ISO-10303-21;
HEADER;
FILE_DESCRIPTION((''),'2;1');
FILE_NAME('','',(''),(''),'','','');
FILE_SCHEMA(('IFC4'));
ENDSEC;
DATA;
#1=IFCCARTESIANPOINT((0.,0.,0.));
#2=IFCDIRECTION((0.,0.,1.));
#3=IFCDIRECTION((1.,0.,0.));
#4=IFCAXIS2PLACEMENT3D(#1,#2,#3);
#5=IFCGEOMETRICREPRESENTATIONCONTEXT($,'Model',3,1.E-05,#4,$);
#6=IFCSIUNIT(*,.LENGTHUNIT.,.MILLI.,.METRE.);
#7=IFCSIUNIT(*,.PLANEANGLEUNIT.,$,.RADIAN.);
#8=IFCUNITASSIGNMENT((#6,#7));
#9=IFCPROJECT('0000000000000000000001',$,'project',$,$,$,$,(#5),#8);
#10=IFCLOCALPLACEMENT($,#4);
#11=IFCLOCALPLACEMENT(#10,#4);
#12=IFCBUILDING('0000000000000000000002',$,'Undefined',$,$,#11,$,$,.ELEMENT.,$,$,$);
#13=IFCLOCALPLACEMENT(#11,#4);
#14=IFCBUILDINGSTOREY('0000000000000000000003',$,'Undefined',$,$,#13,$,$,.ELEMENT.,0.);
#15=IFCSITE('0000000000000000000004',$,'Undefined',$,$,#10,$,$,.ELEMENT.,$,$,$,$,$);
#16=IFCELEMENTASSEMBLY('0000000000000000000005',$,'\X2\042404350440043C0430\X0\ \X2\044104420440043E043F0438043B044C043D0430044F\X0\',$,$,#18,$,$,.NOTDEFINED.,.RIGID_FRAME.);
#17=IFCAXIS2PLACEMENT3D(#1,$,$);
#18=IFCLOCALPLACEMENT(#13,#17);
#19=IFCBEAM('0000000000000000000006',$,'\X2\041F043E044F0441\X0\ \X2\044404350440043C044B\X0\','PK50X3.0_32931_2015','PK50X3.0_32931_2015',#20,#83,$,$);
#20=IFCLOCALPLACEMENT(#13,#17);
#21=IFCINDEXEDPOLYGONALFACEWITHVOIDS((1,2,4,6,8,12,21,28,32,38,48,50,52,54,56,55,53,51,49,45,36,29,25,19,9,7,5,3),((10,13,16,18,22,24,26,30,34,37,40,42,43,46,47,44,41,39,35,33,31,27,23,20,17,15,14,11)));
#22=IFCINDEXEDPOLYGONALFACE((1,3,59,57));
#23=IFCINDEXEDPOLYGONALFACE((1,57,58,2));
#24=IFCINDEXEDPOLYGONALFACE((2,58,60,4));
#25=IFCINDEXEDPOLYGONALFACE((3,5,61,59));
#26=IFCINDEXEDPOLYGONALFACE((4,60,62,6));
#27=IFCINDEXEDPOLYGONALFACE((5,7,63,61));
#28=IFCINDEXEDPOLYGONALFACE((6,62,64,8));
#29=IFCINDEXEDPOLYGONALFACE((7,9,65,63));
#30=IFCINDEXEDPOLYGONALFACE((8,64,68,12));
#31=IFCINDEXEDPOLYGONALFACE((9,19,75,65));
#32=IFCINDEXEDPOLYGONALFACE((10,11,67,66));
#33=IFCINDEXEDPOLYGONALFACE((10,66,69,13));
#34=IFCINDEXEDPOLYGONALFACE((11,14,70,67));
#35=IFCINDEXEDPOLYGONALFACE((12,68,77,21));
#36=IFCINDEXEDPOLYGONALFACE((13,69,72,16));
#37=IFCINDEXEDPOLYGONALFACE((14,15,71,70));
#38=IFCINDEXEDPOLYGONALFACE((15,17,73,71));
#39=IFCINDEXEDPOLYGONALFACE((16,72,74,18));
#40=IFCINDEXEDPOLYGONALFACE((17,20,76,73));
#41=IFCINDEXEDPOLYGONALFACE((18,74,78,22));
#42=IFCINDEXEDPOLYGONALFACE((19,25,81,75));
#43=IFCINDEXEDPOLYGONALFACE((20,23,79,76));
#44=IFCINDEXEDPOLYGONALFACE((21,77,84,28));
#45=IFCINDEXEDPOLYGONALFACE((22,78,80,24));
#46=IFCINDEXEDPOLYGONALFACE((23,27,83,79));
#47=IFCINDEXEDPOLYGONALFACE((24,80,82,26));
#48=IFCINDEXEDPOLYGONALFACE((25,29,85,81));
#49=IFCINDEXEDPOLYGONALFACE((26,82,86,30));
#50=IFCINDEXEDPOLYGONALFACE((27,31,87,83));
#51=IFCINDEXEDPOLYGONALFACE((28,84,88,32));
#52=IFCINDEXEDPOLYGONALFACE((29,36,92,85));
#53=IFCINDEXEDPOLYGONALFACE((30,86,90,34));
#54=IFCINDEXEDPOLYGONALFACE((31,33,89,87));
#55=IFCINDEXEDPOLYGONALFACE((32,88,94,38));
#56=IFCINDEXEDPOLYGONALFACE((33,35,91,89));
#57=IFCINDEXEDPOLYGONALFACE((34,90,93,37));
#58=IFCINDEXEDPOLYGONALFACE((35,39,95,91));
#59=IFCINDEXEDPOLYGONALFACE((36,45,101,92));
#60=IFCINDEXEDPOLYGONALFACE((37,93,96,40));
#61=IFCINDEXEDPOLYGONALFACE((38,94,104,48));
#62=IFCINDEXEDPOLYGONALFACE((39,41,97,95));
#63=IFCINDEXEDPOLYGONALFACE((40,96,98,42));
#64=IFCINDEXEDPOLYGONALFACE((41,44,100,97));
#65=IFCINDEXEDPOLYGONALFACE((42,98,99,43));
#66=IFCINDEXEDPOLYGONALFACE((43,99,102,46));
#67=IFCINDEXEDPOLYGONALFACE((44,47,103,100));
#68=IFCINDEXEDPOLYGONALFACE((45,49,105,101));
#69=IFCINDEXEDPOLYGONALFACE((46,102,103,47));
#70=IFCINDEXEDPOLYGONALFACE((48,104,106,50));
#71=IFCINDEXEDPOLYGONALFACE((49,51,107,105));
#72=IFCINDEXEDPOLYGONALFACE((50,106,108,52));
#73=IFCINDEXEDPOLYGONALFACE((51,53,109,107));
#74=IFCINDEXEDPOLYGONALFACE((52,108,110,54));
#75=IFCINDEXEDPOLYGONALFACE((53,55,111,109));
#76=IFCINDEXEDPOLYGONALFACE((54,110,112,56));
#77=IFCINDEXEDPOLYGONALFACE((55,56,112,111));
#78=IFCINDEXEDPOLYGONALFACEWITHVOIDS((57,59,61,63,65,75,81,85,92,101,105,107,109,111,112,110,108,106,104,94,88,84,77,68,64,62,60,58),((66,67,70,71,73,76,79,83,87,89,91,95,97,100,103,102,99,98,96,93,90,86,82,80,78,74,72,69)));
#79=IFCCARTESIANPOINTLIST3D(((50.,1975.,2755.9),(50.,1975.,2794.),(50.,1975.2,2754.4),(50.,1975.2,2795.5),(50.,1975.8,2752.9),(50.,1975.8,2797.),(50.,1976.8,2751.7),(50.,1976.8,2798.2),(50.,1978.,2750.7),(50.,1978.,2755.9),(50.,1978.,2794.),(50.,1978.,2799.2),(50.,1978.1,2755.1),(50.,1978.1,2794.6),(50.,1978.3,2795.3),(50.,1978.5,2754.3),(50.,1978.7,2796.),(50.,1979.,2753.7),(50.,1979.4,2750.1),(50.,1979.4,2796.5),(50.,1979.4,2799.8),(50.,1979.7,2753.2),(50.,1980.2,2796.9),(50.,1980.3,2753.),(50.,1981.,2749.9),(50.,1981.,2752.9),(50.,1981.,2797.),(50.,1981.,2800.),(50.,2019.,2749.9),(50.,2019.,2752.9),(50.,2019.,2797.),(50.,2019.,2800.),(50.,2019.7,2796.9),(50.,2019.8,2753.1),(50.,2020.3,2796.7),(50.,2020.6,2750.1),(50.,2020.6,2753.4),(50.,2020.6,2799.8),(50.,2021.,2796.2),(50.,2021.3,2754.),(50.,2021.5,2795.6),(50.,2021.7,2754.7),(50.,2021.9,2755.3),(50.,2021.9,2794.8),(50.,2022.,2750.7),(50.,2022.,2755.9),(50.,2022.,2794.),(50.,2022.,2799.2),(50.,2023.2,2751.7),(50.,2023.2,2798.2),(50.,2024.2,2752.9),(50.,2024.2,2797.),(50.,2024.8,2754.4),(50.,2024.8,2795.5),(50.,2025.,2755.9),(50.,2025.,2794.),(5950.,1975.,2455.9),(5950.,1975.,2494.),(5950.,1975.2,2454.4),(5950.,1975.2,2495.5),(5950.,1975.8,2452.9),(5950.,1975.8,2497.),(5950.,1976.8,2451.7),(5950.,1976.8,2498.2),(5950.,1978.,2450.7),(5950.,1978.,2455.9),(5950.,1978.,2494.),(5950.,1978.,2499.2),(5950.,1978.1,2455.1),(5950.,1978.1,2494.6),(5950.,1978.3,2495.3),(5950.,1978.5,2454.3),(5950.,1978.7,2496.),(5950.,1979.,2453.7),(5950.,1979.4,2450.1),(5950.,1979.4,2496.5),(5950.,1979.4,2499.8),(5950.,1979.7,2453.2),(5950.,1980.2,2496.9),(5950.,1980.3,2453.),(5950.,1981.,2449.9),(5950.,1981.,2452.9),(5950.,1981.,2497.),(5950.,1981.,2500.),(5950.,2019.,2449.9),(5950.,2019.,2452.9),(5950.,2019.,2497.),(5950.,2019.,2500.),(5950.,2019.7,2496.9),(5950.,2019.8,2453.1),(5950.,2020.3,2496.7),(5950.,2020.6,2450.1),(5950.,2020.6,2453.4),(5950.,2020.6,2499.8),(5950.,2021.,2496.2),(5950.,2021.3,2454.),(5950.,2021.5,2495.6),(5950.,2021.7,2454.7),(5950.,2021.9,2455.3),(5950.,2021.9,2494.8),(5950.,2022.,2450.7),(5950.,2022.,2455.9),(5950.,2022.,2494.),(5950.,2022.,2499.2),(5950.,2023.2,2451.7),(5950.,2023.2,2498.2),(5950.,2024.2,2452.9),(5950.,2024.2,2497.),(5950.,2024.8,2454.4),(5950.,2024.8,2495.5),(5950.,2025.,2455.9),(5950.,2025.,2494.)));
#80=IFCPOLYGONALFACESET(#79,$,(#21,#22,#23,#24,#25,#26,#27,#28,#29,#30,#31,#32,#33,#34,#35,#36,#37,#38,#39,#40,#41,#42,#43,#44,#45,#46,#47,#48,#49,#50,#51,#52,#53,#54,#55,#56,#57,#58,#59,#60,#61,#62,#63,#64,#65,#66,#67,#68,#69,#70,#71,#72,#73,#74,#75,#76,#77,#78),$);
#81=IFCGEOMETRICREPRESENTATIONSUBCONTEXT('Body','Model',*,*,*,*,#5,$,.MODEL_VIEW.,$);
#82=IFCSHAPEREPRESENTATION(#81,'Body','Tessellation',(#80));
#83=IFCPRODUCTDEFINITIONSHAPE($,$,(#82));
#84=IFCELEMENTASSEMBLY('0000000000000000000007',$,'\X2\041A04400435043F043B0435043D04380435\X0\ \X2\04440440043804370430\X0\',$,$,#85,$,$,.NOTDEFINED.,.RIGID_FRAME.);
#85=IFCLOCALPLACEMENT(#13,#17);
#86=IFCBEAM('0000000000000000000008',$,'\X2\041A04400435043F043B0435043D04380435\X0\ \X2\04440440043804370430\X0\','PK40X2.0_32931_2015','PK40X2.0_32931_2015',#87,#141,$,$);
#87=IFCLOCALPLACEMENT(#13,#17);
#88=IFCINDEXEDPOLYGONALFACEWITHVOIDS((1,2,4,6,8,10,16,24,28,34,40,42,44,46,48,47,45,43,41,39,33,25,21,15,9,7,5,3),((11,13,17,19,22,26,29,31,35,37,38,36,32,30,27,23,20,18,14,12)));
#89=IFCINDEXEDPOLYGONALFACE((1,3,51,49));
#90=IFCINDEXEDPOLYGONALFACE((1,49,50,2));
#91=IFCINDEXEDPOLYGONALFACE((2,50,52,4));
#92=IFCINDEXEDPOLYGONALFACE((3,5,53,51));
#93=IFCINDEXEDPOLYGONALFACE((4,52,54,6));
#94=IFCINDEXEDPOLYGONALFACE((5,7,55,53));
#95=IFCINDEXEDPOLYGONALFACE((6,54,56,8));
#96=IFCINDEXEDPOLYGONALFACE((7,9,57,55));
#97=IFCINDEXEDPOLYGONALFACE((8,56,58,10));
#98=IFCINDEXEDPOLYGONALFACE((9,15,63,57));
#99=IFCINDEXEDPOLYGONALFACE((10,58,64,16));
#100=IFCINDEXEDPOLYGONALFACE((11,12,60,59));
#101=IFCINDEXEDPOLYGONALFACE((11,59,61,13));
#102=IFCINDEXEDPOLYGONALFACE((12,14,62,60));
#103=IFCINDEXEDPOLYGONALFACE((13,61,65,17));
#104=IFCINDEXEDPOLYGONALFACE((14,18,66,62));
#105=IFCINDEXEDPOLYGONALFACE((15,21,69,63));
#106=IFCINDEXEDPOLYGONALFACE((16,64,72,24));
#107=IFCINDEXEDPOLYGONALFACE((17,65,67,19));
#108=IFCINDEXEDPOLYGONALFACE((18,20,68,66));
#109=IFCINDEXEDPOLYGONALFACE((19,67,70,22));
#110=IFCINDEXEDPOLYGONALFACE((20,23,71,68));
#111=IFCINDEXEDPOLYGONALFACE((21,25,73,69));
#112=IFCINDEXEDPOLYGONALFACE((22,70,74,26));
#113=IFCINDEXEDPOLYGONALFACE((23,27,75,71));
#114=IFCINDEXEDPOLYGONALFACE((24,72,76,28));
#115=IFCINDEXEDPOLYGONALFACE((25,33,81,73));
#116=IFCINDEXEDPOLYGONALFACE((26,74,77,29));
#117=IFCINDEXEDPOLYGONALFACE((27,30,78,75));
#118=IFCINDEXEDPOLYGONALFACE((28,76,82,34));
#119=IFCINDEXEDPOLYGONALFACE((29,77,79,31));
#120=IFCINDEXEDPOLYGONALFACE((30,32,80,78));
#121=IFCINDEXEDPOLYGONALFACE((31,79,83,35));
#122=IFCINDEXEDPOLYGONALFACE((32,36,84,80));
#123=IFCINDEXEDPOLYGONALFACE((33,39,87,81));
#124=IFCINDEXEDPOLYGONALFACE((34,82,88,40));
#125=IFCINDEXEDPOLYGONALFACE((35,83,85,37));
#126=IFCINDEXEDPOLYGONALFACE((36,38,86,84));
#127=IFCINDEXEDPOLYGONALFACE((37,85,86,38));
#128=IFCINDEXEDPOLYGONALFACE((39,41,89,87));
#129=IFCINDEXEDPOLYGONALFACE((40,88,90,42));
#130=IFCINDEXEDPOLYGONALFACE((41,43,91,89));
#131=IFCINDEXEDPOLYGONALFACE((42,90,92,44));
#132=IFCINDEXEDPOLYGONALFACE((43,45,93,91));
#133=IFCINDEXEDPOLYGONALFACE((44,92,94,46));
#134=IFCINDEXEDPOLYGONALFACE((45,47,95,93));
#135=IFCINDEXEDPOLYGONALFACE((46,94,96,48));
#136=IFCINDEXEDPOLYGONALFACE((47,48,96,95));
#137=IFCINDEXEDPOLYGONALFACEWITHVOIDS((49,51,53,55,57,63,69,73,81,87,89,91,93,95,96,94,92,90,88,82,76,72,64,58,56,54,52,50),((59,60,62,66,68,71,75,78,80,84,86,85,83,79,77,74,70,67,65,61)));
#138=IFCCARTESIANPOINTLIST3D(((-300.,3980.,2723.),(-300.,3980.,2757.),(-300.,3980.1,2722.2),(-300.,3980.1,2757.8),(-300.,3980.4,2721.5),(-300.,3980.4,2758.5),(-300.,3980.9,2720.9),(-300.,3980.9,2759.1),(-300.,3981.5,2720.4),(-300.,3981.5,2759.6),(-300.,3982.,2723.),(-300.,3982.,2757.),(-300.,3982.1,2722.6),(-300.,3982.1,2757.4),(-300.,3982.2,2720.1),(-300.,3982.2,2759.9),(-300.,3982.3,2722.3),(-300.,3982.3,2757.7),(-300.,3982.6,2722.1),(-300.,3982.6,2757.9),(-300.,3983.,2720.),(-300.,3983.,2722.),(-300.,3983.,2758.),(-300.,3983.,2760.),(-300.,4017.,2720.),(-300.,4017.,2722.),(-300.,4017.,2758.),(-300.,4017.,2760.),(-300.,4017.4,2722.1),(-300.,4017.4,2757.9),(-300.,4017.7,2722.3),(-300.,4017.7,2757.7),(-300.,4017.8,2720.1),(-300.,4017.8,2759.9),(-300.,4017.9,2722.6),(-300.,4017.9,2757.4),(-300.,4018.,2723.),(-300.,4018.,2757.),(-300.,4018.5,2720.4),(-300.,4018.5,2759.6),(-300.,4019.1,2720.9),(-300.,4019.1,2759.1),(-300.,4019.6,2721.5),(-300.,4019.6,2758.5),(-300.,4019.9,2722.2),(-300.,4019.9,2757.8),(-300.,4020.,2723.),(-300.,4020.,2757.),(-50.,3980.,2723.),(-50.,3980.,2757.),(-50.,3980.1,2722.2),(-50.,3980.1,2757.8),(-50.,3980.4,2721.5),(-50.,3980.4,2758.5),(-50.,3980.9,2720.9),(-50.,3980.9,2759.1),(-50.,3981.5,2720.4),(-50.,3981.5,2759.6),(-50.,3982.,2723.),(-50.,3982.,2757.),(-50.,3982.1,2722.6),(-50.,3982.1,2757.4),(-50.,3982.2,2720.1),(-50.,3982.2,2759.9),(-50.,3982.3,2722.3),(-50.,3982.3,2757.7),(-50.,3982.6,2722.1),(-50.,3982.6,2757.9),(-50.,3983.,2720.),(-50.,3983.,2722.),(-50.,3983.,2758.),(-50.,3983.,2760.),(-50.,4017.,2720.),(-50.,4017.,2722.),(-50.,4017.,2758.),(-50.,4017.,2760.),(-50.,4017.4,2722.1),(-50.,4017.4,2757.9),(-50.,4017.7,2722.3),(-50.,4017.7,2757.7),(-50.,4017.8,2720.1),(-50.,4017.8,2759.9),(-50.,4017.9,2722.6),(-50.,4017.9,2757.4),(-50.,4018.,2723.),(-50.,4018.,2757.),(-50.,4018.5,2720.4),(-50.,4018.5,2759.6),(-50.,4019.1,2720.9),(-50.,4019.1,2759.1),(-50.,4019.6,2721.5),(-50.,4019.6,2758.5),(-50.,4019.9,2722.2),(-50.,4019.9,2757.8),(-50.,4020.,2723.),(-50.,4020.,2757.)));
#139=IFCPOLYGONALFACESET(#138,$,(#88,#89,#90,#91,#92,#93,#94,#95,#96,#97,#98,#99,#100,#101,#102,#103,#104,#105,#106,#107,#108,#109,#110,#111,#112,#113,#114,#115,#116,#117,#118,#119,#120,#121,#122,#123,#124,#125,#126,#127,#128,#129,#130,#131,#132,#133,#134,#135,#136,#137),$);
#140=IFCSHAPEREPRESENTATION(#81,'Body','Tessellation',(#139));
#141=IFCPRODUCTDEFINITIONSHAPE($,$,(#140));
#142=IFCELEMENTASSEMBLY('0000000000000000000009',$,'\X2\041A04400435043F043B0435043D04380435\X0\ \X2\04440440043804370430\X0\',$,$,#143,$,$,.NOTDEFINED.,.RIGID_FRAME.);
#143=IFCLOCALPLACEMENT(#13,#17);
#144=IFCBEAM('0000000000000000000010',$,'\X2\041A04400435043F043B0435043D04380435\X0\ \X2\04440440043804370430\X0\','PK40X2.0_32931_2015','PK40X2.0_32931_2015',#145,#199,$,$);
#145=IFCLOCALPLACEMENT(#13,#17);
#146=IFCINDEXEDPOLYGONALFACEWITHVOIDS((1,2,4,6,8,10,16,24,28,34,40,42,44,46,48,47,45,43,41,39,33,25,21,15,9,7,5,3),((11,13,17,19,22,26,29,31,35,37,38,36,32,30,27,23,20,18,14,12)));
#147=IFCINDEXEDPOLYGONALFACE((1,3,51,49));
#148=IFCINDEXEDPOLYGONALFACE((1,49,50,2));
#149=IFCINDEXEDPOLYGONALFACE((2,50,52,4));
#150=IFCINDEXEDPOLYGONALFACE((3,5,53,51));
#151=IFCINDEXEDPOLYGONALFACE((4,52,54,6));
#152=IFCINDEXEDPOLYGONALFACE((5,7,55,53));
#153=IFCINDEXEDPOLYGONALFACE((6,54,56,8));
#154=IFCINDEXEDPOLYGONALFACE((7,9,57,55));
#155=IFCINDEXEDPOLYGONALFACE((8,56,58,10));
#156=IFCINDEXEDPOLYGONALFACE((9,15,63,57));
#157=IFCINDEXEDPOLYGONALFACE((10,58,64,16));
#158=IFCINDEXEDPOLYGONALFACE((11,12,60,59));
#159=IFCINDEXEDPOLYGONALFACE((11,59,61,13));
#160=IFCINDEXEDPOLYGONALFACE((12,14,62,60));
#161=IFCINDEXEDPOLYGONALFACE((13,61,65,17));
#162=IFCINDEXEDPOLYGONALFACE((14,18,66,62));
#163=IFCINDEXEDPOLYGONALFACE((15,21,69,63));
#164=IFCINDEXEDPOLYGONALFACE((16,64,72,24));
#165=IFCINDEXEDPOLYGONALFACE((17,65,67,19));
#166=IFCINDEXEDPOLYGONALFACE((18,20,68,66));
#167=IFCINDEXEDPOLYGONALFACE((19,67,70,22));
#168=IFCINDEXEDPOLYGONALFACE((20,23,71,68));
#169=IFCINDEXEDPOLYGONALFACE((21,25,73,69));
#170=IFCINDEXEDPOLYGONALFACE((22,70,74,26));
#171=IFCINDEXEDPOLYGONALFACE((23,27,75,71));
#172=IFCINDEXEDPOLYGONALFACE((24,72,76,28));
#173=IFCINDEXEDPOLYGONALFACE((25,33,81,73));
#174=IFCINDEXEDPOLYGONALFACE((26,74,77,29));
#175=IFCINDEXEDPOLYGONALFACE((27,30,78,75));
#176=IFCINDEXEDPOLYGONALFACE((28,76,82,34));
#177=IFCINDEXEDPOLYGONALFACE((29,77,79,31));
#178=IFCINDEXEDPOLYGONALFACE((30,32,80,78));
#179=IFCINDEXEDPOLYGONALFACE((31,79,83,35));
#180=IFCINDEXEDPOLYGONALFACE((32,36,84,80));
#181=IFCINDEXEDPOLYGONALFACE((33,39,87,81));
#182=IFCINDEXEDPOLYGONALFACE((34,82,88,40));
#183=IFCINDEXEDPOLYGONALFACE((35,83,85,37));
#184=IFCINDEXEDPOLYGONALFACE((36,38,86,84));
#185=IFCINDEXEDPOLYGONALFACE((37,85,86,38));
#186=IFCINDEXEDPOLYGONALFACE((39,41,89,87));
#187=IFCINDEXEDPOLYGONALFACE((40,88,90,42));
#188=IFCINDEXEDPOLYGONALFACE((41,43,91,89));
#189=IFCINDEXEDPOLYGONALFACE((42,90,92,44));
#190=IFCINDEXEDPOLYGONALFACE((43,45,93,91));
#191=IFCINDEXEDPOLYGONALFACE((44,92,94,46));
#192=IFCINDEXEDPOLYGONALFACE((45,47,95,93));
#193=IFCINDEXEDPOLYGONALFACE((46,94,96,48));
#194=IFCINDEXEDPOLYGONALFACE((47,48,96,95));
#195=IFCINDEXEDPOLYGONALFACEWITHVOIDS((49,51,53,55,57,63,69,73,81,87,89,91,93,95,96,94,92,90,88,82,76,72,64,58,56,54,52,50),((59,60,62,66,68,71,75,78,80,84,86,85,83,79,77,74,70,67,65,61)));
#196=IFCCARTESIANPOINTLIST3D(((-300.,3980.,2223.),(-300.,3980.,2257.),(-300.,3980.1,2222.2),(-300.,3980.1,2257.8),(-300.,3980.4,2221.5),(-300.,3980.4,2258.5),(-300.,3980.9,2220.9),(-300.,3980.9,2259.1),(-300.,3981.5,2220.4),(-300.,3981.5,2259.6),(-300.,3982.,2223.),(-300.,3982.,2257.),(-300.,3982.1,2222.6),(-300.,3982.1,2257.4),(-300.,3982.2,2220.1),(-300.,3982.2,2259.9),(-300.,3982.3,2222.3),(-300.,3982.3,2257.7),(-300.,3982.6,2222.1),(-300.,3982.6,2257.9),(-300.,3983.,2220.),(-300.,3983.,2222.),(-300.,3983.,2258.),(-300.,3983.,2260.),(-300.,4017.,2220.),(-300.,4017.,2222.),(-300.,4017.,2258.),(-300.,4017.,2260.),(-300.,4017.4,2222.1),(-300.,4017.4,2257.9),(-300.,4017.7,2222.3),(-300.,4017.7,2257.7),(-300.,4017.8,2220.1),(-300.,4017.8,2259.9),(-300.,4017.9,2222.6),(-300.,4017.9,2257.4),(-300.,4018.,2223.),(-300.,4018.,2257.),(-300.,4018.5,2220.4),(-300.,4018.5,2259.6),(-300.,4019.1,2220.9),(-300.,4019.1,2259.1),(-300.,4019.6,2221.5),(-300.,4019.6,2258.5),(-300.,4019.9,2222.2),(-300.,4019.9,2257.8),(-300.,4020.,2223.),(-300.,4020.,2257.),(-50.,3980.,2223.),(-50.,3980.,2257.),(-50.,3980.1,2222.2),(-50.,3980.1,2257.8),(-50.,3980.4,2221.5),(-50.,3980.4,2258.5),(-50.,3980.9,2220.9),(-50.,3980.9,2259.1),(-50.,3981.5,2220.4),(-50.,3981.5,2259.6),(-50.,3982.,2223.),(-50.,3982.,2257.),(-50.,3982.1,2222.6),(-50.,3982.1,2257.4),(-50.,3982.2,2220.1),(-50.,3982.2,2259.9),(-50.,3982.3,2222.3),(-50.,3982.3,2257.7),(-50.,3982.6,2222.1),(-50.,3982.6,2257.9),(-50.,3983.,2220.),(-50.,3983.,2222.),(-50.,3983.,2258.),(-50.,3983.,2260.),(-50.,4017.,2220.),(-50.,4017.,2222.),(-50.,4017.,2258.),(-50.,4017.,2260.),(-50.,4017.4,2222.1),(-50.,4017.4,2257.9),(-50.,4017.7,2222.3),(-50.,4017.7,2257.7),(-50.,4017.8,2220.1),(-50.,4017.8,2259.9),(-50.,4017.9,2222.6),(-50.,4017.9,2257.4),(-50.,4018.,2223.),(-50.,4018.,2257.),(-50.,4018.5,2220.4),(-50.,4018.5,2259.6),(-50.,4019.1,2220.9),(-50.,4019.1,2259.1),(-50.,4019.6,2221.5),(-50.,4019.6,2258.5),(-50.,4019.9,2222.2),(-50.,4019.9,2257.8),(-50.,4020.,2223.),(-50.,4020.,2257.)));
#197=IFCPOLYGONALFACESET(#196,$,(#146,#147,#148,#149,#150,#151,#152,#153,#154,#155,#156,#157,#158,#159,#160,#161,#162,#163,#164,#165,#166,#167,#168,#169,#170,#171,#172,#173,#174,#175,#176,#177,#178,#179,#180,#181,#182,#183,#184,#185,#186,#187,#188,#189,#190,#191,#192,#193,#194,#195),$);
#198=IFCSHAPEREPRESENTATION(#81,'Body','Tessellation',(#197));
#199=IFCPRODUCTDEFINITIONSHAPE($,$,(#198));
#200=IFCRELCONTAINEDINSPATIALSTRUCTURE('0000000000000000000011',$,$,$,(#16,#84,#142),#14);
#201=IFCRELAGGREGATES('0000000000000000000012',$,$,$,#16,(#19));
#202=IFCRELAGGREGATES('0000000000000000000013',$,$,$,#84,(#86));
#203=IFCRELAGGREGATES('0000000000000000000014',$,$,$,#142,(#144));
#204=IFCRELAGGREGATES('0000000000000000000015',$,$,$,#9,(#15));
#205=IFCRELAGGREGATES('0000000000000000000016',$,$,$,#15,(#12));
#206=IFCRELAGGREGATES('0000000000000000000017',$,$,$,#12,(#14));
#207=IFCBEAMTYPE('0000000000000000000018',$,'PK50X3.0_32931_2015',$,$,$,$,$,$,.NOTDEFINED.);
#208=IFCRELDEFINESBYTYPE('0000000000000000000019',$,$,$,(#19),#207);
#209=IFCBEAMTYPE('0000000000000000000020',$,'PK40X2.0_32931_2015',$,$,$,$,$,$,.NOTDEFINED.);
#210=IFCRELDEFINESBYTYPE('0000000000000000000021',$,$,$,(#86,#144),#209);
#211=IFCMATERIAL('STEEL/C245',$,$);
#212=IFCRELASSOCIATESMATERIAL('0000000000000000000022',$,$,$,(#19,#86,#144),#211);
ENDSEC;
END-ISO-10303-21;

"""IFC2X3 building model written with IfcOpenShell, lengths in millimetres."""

from ifc_helpers import new_model, si_unit, frame, origin_with_axes, origin_2d_with_axis, place, context, subcontext, project, spatial, hollow_rectangle, extrude, clip, halfspace, material, type_object, element, aggregate, save


model = new_model("IFC2X3")

# Units and contexts
model_context = context("Model", 3, precision=1e-05, world=origin_with_axes())
body_context = subcontext(model_context, "Body", "Model", "MODEL_VIEW")
ifc_project = project(units=[si_unit("LENGTHUNIT", "METRE", prefix="MILLI"), si_unit("PLANEANGLEUNIT", "RADIAN")], contexts=[model_context])

# Site, building, storey
site_placement = place(None, origin_with_axes())
site = spatial("IfcSite", under=ifc_project, at=site_placement, Name="Undefined", CompositionType="ELEMENT")
building_placement = place(site_placement, origin_with_axes())
building = spatial("IfcBuilding", under=site, at=building_placement, Name="Undefined", CompositionType="ELEMENT")
storey_placement = place(building_placement, origin_with_axes())
storey = spatial("IfcBuildingStorey", under=building, at=storey_placement, Name="Undefined", CompositionType="ELEMENT", Elevation=0.0)

# Shared definitions
ifc_material_1 = material(Name="STEEL/C245")

# Element assembly, beam
assembly_1_placement = place(storey_placement, origin_with_axes())
assembly_1 = element("IfcElementAssembly", 1, at=assembly_1_placement, inside=storey, Name="Ферма стропильная", AssemblyPlace="NOTDEFINED", PredefinedType="RIGID_FRAME")
beam_type_1 = type_object("IfcBeamType", Name="PK50X3.0_32931_2015", PredefinedType="NOTDEFINED")
beam_1_placement = place(assembly_1_placement, frame((48.7, 2000.0, 2775.0), z_axis=(0.050782, 0.0, 0.99871), x_axis=(0.99871, 0.0, -0.050782)))
beam_1 = element("IfcBeam", 2, at=beam_1_placement, type_object=beam_type_1, material=ifc_material_1, Name="Пояс фермы", Description="PK50X3.0_32931_2015", ObjectType="PK50X3.0_32931_2015", context=body_context, shape_type="Clipping", body=[
    clip(clip(extrude(hollow_rectangle(XDim=50.0, YDim=50.0, WallThickness=3.0, InnerFilletRadius=3.0, OuterFilletRadius=6.0, at=origin_2d_with_axis()), frame((5911.5, 0.0, 0.0), z_axis=(-1.0, 0.0, 0.0), x_axis=(0.0, -1.0, 0.0)), (0.0, 0.0, 1.0), 5912.8), halfspace(frame((5907.6, 0.0, 25.0), z_axis=(0.99871, 0.0, 0.050782), x_axis=(0.0, -1.0, 0.0)), False)), halfspace(frame((0.0, 0.0, 25.0), z_axis=(0.99871, 0.0, 0.050782), x_axis=(0.0, -1.0, 0.0)), True)),
])
aggregate(assembly_1, [beam_1])

# Element assemblies, beams
assembly_2_placement = place(storey_placement, origin_with_axes())
assembly_2 = element("IfcElementAssembly", 3, at=assembly_2_placement, inside=storey, Name="Крепление фриза", AssemblyPlace="NOTDEFINED", PredefinedType="RIGID_FRAME")
beam_type_2 = type_object("IfcBeamType", Name="PK40X2.0_32931_2015", PredefinedType="NOTDEFINED")
beam_2_placement = place(assembly_2_placement, frame((-300.0, 4000.0, 2740.0), z_axis=(0.0, 0.0, -1.0), x_axis=(1.0, 0.0, 0.0)))
beam_2 = element("IfcBeam", 4, at=beam_2_placement, type_object=beam_type_2, material=ifc_material_1, Name="Крепление фриза", Description="PK40X2.0_32931_2015", ObjectType="PK40X2.0_32931_2015", context=body_context, shape_type="SweptSolid", body=[
    extrude(hollow_rectangle(XDim=40.0, YDim=40.0, WallThickness=2.0, InnerFilletRadius=1.0, OuterFilletRadius=3.0, at=origin_2d_with_axis()), frame((250.0, 0.0, 0.0), z_axis=(-1.0, 0.0, 0.0), x_axis=(0.0, -1.0, 0.0)), (0.0, 0.0, 1.0), 250.0),
])
aggregate(assembly_2, [beam_2])
assembly_3_placement = place(storey_placement, origin_with_axes())
assembly_3 = element("IfcElementAssembly", 5, at=assembly_3_placement, inside=storey, Name="Крепление фриза", AssemblyPlace="NOTDEFINED", PredefinedType="RIGID_FRAME")
beam_3_placement = place(assembly_3_placement, frame((-300.0, 4000.0, 2240.0), z_axis=(0.0, 0.0, -1.0), x_axis=(1.0, 0.0, 0.0)))
beam_3 = element("IfcBeam", 6, at=beam_3_placement, type_object=beam_type_2, material=ifc_material_1, Name="Крепление фриза", Description="PK40X2.0_32931_2015", ObjectType="PK40X2.0_32931_2015", context=body_context, shape_type="SweptSolid", body=[
    extrude(hollow_rectangle(XDim=40.0, YDim=40.0, WallThickness=2.0, InnerFilletRadius=1.0, OuterFilletRadius=3.0, at=origin_2d_with_axis()), frame((250.0, 0.0, 0.0), z_axis=(-1.0, 0.0, 0.0), x_axis=(0.0, -1.0, 0.0)), (0.0, 0.0, 1.0), 250.0),
])
aggregate(assembly_3, [beam_3])

save(model, "model.ifc")
